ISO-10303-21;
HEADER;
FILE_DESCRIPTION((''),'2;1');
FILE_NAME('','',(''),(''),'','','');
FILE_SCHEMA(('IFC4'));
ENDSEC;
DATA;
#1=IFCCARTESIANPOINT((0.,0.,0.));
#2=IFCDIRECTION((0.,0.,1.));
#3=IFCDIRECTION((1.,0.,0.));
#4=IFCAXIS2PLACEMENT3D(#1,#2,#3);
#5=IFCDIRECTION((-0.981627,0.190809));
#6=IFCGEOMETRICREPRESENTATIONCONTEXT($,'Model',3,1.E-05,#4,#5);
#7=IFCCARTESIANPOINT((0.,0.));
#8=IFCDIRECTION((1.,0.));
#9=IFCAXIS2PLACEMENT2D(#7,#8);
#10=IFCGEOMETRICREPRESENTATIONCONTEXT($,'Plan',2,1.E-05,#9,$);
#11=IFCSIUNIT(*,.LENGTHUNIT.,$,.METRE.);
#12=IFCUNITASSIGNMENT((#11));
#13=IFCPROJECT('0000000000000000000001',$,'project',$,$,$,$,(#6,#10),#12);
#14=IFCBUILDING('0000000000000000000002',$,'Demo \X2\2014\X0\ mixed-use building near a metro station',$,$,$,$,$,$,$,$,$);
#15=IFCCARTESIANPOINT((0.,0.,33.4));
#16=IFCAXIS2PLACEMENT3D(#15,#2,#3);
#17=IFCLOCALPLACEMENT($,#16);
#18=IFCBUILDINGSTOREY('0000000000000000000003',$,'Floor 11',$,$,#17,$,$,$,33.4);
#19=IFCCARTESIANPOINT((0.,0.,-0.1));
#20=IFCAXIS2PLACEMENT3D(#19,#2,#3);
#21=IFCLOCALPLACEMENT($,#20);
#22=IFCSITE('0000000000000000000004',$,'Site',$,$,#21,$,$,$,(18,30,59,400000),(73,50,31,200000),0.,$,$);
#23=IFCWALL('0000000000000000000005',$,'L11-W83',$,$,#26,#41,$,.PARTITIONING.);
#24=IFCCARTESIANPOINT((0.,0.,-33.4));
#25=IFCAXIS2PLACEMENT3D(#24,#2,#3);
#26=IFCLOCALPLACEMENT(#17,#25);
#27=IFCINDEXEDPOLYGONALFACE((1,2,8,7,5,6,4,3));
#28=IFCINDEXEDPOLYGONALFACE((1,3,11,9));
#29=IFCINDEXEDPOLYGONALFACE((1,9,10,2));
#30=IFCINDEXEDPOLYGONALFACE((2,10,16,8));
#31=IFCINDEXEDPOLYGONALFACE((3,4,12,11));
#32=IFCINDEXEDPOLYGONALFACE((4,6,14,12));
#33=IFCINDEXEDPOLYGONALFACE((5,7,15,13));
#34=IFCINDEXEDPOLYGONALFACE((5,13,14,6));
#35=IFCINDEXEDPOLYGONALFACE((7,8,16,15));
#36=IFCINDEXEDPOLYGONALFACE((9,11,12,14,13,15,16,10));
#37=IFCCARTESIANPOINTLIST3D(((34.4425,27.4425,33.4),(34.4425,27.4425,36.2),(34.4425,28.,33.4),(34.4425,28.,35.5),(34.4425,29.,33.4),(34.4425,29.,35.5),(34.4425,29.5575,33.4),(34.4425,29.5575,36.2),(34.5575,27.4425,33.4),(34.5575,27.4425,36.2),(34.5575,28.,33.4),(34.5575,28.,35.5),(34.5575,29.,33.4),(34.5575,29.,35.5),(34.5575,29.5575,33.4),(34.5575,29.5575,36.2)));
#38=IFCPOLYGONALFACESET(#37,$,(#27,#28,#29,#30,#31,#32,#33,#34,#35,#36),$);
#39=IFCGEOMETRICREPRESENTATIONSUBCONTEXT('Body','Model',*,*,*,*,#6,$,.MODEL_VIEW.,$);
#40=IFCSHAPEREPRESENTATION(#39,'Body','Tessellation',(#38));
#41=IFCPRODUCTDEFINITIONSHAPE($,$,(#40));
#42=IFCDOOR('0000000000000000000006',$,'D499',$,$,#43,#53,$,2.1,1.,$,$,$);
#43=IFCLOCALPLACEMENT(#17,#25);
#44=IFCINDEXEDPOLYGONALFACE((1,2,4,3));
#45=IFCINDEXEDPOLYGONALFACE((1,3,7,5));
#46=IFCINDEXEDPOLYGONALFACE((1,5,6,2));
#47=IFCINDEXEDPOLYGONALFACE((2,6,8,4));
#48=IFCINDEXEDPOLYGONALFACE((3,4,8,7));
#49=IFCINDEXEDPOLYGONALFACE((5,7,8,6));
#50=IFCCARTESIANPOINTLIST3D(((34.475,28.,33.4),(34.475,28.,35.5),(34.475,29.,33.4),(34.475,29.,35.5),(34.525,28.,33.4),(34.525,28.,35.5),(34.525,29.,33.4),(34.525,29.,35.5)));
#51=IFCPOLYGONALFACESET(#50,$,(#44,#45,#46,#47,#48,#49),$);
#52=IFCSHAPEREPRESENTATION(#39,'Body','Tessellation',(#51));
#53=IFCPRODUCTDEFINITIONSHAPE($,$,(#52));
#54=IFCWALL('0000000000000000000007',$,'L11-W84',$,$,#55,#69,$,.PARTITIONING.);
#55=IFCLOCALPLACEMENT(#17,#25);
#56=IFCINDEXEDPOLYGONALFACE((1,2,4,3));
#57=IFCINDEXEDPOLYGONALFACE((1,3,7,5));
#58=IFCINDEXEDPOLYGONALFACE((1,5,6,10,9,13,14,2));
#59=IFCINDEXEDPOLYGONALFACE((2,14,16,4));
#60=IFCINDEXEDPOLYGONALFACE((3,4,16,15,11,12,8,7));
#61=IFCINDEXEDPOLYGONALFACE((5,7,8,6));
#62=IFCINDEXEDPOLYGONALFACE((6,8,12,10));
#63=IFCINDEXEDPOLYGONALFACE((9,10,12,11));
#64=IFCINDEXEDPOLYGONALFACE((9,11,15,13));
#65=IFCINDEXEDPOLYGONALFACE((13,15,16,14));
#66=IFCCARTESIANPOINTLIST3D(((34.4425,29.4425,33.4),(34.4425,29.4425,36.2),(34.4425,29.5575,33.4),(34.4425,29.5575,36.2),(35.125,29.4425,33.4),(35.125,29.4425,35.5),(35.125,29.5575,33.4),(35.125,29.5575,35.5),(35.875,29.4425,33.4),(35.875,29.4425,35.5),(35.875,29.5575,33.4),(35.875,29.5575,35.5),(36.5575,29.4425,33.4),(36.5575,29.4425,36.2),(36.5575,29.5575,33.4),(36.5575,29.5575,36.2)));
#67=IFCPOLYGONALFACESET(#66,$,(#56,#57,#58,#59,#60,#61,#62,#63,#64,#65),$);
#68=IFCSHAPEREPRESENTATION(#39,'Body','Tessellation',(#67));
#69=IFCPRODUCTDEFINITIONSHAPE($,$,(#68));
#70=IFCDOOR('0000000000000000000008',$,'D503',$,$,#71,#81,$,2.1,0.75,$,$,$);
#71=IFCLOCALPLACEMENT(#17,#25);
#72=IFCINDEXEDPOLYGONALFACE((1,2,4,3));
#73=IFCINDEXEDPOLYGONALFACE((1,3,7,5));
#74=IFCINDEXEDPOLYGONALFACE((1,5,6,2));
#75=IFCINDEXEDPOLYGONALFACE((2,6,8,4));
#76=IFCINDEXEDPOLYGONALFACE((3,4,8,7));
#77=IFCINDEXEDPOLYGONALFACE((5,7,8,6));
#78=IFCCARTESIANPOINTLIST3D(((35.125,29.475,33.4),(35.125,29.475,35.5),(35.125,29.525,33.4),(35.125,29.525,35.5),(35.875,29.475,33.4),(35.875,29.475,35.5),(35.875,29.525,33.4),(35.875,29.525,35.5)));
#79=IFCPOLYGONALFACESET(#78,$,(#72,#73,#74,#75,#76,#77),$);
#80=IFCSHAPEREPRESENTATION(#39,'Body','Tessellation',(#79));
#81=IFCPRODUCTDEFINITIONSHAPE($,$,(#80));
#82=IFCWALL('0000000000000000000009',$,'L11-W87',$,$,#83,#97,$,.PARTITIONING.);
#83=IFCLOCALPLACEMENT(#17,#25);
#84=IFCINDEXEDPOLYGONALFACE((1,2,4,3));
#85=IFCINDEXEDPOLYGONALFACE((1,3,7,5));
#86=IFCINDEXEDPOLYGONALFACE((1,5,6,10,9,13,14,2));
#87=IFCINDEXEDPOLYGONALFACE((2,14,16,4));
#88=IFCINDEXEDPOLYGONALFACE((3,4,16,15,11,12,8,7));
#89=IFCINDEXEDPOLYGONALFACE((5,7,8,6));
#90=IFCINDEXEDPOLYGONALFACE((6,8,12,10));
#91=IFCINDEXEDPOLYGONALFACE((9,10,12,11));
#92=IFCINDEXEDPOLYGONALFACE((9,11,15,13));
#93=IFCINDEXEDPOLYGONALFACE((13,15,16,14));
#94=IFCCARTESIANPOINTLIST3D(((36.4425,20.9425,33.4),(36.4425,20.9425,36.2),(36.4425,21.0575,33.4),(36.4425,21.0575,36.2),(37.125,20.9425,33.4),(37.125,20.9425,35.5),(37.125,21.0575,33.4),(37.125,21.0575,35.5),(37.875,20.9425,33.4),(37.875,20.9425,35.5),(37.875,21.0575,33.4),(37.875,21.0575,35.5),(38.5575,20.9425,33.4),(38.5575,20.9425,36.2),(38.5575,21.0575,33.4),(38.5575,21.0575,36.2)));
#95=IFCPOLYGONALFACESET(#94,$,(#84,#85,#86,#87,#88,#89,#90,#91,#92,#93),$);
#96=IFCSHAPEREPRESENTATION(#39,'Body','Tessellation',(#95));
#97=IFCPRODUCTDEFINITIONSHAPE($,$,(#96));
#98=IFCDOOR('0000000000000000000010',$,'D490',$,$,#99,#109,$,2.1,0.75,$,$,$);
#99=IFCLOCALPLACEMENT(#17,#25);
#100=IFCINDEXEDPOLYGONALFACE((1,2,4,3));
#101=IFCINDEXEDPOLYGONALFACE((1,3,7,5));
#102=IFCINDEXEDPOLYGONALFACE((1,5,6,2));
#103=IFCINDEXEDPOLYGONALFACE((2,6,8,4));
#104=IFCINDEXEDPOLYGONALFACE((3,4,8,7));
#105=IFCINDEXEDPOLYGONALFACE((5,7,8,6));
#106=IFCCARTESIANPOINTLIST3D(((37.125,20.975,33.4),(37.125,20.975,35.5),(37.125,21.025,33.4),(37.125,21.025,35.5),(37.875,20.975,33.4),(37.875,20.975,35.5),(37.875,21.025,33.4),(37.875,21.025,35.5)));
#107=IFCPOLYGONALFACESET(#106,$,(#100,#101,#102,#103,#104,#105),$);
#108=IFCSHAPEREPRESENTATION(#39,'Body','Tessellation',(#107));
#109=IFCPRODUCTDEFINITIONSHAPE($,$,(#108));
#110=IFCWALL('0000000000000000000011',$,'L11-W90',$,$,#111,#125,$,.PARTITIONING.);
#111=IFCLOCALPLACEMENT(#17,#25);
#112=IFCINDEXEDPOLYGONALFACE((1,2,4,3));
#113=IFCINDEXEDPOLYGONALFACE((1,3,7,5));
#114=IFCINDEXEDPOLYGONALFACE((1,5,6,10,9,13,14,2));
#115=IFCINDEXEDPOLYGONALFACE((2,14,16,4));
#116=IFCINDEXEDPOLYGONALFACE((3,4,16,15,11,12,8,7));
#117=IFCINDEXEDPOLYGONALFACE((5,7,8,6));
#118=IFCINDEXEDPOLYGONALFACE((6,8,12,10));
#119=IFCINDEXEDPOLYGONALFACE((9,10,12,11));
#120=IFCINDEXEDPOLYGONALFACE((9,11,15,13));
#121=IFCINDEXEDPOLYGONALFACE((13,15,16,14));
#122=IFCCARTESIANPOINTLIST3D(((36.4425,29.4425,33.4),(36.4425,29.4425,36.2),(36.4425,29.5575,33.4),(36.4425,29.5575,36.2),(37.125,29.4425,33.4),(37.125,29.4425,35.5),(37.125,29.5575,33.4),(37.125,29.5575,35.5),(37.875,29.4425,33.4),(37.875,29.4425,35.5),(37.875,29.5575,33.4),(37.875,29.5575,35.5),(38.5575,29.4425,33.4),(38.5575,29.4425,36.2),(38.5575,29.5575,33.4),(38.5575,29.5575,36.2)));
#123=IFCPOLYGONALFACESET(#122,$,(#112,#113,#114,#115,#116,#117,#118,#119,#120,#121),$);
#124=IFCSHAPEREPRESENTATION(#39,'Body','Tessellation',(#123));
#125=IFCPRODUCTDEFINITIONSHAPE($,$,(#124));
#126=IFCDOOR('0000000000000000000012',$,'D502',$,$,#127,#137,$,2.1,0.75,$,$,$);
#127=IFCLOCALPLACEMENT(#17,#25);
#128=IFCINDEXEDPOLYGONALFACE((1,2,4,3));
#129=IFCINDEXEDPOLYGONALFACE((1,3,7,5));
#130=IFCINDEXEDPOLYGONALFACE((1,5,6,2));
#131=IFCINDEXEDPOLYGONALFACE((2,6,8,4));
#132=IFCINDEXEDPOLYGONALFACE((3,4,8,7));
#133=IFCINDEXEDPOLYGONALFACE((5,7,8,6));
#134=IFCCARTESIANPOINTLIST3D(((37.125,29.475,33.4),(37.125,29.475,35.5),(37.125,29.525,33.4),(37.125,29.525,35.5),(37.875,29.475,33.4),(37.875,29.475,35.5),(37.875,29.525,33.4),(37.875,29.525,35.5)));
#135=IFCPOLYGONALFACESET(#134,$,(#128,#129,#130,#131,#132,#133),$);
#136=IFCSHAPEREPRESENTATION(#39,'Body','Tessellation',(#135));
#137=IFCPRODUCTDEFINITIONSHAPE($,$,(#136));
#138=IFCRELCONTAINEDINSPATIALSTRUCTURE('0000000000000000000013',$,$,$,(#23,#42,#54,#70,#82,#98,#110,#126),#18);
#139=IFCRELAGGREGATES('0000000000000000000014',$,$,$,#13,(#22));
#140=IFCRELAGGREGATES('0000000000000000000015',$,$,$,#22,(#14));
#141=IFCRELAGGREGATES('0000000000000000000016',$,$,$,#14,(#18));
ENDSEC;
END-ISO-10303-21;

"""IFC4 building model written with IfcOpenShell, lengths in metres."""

from ifc_helpers import new_model, si_unit, direction, frame, origin_with_axes, origin_2d_with_axis, place, context, subcontext, project, spatial, line, indexed_curve, outline, extrude, element, fill, save


model = new_model("IFC4")

# Units and contexts
model_context = context("Model", 3, precision=1e-05, world=origin_with_axes(), true_north=direction((-0.981627, 0.190809)))
plan_context = context("Plan", 2, precision=1e-05, world=origin_2d_with_axis())
body_context = subcontext(model_context, "Body", "Model", "MODEL_VIEW")
ifc_project = project(units=[si_unit("LENGTHUNIT", "METRE")], contexts=[model_context, plan_context])

# Site, building, storey
site_placement = place(None, frame((0.0, 0.0, -0.1), z_axis=(0.0, 0.0, 1.0), x_axis=(1.0, 0.0, 0.0)))
site = spatial("IfcSite", under=ifc_project, at=site_placement, Name="Site", RefLatitude=(18, 30, 59, 400000), RefLongitude=(73, 50, 31, 200000), RefElevation=0.0)
building = spatial("IfcBuilding", under=site, Name="Demo — mixed-use building near a metro station")
storey_placement = place(None, frame((0.0, 0.0, 33.4), z_axis=(0.0, 0.0, 1.0), x_axis=(1.0, 0.0, 0.0)))
storey = spatial("IfcBuildingStorey", under=building, at=storey_placement, Name="Floor 11", Elevation=33.4)

# Walls, openings, doors
wall_1_placement = place(storey_placement, frame((0.0, 0.0, -33.4), z_axis=(0.0, 0.0, 1.0), x_axis=(1.0, 0.0, 0.0)))
wall_1 = element("IfcWall", 1, at=wall_1_placement, inside=storey, Name="L11-W83", PredefinedType="PARTITIONING", context=body_context, shape_type="SweptSolid", body=[
    extrude(outline(indexed_curve([(34.4425, 27.4425), (34.4425, 29.5575), (34.5575, 29.5575), (34.5575, 27.4425)], segments=[line(1, 2, 3, 4, 1)])), frame((0.0, 0.0, 33.4), z_axis=(0.0, 0.0, 1.0), x_axis=(1.0, 0.0, 0.0)), (0.0, 0.0, 1.0), 2.8),
])
opening_1_placement = place(wall_1_placement, origin_with_axes())
opening_1 = element("IfcOpeningElement", 2, at=opening_1_placement, cuts=wall_1, context=body_context, shape_type="SweptSolid", body=[
    extrude(outline(indexed_curve([(34.3925, 28.0), (34.3925, 29.0), (34.6075, 29.0), (34.6075, 28.0)], segments=[line(1, 2, 3, 4, 1)])), frame((0.0, 0.0, 33.4), z_axis=(0.0, 0.0, 1.0), x_axis=(1.0, 0.0, 0.0)), (0.0, 0.0, 1.0), 2.1),
])
door_1_placement = place(storey_placement, frame((0.0, 0.0, -33.4), z_axis=(0.0, 0.0, 1.0), x_axis=(1.0, 0.0, 0.0)))
door_1 = element("IfcDoor", 3, at=door_1_placement, inside=storey, Name="D499", OverallHeight=2.1, OverallWidth=1.0, context=body_context, shape_type="SweptSolid", body=[
    extrude(outline(indexed_curve([(34.475, 28.0), (34.475, 29.0), (34.525, 29.0), (34.525, 28.0)], segments=[line(1, 2, 3, 4, 1)])), frame((0.0, 0.0, 33.4), z_axis=(0.0, 0.0, 1.0), x_axis=(1.0, 0.0, 0.0)), (0.0, 0.0, 1.0), 2.1),
])
fill(opening_1, door_1)
wall_2_placement = place(storey_placement, frame((0.0, 0.0, -33.4), z_axis=(0.0, 0.0, 1.0), x_axis=(1.0, 0.0, 0.0)))
wall_2 = element("IfcWall", 4, at=wall_2_placement, inside=storey, Name="L11-W84", PredefinedType="PARTITIONING", context=body_context, shape_type="SweptSolid", body=[
    extrude(outline(indexed_curve([(36.5575, 29.4425), (34.4425, 29.4425), (34.4425, 29.5575), (36.5575, 29.5575)], segments=[line(1, 2, 3, 4, 1)])), frame((0.0, 0.0, 33.4), z_axis=(0.0, 0.0, 1.0), x_axis=(1.0, 0.0, 0.0)), (0.0, 0.0, 1.0), 2.8),
])
opening_2_placement = place(wall_2_placement, origin_with_axes())
opening_2 = element("IfcOpeningElement", 5, at=opening_2_placement, cuts=wall_2, context=body_context, shape_type="SweptSolid", body=[
    extrude(outline(indexed_curve([(35.875, 29.3925), (35.125, 29.3925), (35.125, 29.6075), (35.875, 29.6075)], segments=[line(1, 2, 3, 4, 1)])), frame((0.0, 0.0, 33.4), z_axis=(0.0, 0.0, 1.0), x_axis=(1.0, 0.0, 0.0)), (0.0, 0.0, 1.0), 2.1),
])
door_2_placement = place(storey_placement, frame((0.0, 0.0, -33.4), z_axis=(0.0, 0.0, 1.0), x_axis=(1.0, 0.0, 0.0)))
door_2 = element("IfcDoor", 6, at=door_2_placement, inside=storey, Name="D503", OverallHeight=2.1, OverallWidth=0.75, context=body_context, shape_type="SweptSolid", body=[
    extrude(outline(indexed_curve([(35.875, 29.475), (35.125, 29.475), (35.125, 29.525), (35.875, 29.525)], segments=[line(1, 2, 3, 4, 1)])), frame((0.0, 0.0, 33.4), z_axis=(0.0, 0.0, 1.0), x_axis=(1.0, 0.0, 0.0)), (0.0, 0.0, 1.0), 2.1),
])
fill(opening_2, door_2)

# Wall, opening, door
wall_3_placement = place(storey_placement, frame((0.0, 0.0, -33.4), z_axis=(0.0, 0.0, 1.0), x_axis=(1.0, 0.0, 0.0)))
wall_3 = element("IfcWall", 7, at=wall_3_placement, inside=storey, Name="L11-W87", PredefinedType="PARTITIONING", context=body_context, shape_type="SweptSolid", body=[
    extrude(outline(indexed_curve([(38.5575, 20.9425), (36.4425, 20.9425), (36.4425, 21.0575), (38.5575, 21.0575)], segments=[line(1, 2, 3, 4, 1)])), frame((0.0, 0.0, 33.4), z_axis=(0.0, 0.0, 1.0), x_axis=(1.0, 0.0, 0.0)), (0.0, 0.0, 1.0), 2.8),
])
opening_3_placement = place(wall_3_placement, origin_with_axes())
opening_3 = element("IfcOpeningElement", 8, at=opening_3_placement, cuts=wall_3, context=body_context, shape_type="SweptSolid", body=[
    extrude(outline(indexed_curve([(37.875, 20.8925), (37.125, 20.8925), (37.125, 21.1075), (37.875, 21.1075)], segments=[line(1, 2, 3, 4, 1)])), frame((0.0, 0.0, 33.4), z_axis=(0.0, 0.0, 1.0), x_axis=(1.0, 0.0, 0.0)), (0.0, 0.0, 1.0), 2.1),
])
door_3_placement = place(storey_placement, frame((0.0, 0.0, -33.4), z_axis=(0.0, 0.0, 1.0), x_axis=(1.0, 0.0, 0.0)))
door_3 = element("IfcDoor", 9, at=door_3_placement, inside=storey, Name="D490", OverallHeight=2.1, OverallWidth=0.75, context=body_context, shape_type="SweptSolid", body=[
    extrude(outline(indexed_curve([(37.875, 20.975), (37.125, 20.975), (37.125, 21.025), (37.875, 21.025)], segments=[line(1, 2, 3, 4, 1)])), frame((0.0, 0.0, 33.4), z_axis=(0.0, 0.0, 1.0), x_axis=(1.0, 0.0, 0.0)), (0.0, 0.0, 1.0), 2.1),
])
fill(opening_3, door_3)

# Wall, opening, door
wall_4_placement = place(storey_placement, frame((0.0, 0.0, -33.4), z_axis=(0.0, 0.0, 1.0), x_axis=(1.0, 0.0, 0.0)))
wall_4 = element("IfcWall", 10, at=wall_4_placement, inside=storey, Name="L11-W90", PredefinedType="PARTITIONING", context=body_context, shape_type="SweptSolid", body=[
    extrude(outline(indexed_curve([(38.5575, 29.4425), (36.4425, 29.4425), (36.4425, 29.5575), (38.5575, 29.5575)], segments=[line(1, 2, 3, 4, 1)])), frame((0.0, 0.0, 33.4), z_axis=(0.0, 0.0, 1.0), x_axis=(1.0, 0.0, 0.0)), (0.0, 0.0, 1.0), 2.8),
])
opening_4_placement = place(wall_4_placement, origin_with_axes())
opening_4 = element("IfcOpeningElement", 11, at=opening_4_placement, cuts=wall_4, context=body_context, shape_type="SweptSolid", body=[
    extrude(outline(indexed_curve([(37.875, 29.3925), (37.125, 29.3925), (37.125, 29.6075), (37.875, 29.6075)], segments=[line(1, 2, 3, 4, 1)])), frame((0.0, 0.0, 33.4), z_axis=(0.0, 0.0, 1.0), x_axis=(1.0, 0.0, 0.0)), (0.0, 0.0, 1.0), 2.1),
])
door_4_placement = place(storey_placement, frame((0.0, 0.0, -33.4), z_axis=(0.0, 0.0, 1.0), x_axis=(1.0, 0.0, 0.0)))
door_4 = element("IfcDoor", 12, at=door_4_placement, inside=storey, Name="D502", OverallHeight=2.1, OverallWidth=0.75, context=body_context, shape_type="SweptSolid", body=[
    extrude(outline(indexed_curve([(37.875, 29.475), (37.125, 29.475), (37.125, 29.525), (37.875, 29.525)], segments=[line(1, 2, 3, 4, 1)])), frame((0.0, 0.0, 33.4), z_axis=(0.0, 0.0, 1.0), x_axis=(1.0, 0.0, 0.0)), (0.0, 0.0, 1.0), 2.1),
])
fill(opening_4, door_4)

save(model, "model.ifc")
